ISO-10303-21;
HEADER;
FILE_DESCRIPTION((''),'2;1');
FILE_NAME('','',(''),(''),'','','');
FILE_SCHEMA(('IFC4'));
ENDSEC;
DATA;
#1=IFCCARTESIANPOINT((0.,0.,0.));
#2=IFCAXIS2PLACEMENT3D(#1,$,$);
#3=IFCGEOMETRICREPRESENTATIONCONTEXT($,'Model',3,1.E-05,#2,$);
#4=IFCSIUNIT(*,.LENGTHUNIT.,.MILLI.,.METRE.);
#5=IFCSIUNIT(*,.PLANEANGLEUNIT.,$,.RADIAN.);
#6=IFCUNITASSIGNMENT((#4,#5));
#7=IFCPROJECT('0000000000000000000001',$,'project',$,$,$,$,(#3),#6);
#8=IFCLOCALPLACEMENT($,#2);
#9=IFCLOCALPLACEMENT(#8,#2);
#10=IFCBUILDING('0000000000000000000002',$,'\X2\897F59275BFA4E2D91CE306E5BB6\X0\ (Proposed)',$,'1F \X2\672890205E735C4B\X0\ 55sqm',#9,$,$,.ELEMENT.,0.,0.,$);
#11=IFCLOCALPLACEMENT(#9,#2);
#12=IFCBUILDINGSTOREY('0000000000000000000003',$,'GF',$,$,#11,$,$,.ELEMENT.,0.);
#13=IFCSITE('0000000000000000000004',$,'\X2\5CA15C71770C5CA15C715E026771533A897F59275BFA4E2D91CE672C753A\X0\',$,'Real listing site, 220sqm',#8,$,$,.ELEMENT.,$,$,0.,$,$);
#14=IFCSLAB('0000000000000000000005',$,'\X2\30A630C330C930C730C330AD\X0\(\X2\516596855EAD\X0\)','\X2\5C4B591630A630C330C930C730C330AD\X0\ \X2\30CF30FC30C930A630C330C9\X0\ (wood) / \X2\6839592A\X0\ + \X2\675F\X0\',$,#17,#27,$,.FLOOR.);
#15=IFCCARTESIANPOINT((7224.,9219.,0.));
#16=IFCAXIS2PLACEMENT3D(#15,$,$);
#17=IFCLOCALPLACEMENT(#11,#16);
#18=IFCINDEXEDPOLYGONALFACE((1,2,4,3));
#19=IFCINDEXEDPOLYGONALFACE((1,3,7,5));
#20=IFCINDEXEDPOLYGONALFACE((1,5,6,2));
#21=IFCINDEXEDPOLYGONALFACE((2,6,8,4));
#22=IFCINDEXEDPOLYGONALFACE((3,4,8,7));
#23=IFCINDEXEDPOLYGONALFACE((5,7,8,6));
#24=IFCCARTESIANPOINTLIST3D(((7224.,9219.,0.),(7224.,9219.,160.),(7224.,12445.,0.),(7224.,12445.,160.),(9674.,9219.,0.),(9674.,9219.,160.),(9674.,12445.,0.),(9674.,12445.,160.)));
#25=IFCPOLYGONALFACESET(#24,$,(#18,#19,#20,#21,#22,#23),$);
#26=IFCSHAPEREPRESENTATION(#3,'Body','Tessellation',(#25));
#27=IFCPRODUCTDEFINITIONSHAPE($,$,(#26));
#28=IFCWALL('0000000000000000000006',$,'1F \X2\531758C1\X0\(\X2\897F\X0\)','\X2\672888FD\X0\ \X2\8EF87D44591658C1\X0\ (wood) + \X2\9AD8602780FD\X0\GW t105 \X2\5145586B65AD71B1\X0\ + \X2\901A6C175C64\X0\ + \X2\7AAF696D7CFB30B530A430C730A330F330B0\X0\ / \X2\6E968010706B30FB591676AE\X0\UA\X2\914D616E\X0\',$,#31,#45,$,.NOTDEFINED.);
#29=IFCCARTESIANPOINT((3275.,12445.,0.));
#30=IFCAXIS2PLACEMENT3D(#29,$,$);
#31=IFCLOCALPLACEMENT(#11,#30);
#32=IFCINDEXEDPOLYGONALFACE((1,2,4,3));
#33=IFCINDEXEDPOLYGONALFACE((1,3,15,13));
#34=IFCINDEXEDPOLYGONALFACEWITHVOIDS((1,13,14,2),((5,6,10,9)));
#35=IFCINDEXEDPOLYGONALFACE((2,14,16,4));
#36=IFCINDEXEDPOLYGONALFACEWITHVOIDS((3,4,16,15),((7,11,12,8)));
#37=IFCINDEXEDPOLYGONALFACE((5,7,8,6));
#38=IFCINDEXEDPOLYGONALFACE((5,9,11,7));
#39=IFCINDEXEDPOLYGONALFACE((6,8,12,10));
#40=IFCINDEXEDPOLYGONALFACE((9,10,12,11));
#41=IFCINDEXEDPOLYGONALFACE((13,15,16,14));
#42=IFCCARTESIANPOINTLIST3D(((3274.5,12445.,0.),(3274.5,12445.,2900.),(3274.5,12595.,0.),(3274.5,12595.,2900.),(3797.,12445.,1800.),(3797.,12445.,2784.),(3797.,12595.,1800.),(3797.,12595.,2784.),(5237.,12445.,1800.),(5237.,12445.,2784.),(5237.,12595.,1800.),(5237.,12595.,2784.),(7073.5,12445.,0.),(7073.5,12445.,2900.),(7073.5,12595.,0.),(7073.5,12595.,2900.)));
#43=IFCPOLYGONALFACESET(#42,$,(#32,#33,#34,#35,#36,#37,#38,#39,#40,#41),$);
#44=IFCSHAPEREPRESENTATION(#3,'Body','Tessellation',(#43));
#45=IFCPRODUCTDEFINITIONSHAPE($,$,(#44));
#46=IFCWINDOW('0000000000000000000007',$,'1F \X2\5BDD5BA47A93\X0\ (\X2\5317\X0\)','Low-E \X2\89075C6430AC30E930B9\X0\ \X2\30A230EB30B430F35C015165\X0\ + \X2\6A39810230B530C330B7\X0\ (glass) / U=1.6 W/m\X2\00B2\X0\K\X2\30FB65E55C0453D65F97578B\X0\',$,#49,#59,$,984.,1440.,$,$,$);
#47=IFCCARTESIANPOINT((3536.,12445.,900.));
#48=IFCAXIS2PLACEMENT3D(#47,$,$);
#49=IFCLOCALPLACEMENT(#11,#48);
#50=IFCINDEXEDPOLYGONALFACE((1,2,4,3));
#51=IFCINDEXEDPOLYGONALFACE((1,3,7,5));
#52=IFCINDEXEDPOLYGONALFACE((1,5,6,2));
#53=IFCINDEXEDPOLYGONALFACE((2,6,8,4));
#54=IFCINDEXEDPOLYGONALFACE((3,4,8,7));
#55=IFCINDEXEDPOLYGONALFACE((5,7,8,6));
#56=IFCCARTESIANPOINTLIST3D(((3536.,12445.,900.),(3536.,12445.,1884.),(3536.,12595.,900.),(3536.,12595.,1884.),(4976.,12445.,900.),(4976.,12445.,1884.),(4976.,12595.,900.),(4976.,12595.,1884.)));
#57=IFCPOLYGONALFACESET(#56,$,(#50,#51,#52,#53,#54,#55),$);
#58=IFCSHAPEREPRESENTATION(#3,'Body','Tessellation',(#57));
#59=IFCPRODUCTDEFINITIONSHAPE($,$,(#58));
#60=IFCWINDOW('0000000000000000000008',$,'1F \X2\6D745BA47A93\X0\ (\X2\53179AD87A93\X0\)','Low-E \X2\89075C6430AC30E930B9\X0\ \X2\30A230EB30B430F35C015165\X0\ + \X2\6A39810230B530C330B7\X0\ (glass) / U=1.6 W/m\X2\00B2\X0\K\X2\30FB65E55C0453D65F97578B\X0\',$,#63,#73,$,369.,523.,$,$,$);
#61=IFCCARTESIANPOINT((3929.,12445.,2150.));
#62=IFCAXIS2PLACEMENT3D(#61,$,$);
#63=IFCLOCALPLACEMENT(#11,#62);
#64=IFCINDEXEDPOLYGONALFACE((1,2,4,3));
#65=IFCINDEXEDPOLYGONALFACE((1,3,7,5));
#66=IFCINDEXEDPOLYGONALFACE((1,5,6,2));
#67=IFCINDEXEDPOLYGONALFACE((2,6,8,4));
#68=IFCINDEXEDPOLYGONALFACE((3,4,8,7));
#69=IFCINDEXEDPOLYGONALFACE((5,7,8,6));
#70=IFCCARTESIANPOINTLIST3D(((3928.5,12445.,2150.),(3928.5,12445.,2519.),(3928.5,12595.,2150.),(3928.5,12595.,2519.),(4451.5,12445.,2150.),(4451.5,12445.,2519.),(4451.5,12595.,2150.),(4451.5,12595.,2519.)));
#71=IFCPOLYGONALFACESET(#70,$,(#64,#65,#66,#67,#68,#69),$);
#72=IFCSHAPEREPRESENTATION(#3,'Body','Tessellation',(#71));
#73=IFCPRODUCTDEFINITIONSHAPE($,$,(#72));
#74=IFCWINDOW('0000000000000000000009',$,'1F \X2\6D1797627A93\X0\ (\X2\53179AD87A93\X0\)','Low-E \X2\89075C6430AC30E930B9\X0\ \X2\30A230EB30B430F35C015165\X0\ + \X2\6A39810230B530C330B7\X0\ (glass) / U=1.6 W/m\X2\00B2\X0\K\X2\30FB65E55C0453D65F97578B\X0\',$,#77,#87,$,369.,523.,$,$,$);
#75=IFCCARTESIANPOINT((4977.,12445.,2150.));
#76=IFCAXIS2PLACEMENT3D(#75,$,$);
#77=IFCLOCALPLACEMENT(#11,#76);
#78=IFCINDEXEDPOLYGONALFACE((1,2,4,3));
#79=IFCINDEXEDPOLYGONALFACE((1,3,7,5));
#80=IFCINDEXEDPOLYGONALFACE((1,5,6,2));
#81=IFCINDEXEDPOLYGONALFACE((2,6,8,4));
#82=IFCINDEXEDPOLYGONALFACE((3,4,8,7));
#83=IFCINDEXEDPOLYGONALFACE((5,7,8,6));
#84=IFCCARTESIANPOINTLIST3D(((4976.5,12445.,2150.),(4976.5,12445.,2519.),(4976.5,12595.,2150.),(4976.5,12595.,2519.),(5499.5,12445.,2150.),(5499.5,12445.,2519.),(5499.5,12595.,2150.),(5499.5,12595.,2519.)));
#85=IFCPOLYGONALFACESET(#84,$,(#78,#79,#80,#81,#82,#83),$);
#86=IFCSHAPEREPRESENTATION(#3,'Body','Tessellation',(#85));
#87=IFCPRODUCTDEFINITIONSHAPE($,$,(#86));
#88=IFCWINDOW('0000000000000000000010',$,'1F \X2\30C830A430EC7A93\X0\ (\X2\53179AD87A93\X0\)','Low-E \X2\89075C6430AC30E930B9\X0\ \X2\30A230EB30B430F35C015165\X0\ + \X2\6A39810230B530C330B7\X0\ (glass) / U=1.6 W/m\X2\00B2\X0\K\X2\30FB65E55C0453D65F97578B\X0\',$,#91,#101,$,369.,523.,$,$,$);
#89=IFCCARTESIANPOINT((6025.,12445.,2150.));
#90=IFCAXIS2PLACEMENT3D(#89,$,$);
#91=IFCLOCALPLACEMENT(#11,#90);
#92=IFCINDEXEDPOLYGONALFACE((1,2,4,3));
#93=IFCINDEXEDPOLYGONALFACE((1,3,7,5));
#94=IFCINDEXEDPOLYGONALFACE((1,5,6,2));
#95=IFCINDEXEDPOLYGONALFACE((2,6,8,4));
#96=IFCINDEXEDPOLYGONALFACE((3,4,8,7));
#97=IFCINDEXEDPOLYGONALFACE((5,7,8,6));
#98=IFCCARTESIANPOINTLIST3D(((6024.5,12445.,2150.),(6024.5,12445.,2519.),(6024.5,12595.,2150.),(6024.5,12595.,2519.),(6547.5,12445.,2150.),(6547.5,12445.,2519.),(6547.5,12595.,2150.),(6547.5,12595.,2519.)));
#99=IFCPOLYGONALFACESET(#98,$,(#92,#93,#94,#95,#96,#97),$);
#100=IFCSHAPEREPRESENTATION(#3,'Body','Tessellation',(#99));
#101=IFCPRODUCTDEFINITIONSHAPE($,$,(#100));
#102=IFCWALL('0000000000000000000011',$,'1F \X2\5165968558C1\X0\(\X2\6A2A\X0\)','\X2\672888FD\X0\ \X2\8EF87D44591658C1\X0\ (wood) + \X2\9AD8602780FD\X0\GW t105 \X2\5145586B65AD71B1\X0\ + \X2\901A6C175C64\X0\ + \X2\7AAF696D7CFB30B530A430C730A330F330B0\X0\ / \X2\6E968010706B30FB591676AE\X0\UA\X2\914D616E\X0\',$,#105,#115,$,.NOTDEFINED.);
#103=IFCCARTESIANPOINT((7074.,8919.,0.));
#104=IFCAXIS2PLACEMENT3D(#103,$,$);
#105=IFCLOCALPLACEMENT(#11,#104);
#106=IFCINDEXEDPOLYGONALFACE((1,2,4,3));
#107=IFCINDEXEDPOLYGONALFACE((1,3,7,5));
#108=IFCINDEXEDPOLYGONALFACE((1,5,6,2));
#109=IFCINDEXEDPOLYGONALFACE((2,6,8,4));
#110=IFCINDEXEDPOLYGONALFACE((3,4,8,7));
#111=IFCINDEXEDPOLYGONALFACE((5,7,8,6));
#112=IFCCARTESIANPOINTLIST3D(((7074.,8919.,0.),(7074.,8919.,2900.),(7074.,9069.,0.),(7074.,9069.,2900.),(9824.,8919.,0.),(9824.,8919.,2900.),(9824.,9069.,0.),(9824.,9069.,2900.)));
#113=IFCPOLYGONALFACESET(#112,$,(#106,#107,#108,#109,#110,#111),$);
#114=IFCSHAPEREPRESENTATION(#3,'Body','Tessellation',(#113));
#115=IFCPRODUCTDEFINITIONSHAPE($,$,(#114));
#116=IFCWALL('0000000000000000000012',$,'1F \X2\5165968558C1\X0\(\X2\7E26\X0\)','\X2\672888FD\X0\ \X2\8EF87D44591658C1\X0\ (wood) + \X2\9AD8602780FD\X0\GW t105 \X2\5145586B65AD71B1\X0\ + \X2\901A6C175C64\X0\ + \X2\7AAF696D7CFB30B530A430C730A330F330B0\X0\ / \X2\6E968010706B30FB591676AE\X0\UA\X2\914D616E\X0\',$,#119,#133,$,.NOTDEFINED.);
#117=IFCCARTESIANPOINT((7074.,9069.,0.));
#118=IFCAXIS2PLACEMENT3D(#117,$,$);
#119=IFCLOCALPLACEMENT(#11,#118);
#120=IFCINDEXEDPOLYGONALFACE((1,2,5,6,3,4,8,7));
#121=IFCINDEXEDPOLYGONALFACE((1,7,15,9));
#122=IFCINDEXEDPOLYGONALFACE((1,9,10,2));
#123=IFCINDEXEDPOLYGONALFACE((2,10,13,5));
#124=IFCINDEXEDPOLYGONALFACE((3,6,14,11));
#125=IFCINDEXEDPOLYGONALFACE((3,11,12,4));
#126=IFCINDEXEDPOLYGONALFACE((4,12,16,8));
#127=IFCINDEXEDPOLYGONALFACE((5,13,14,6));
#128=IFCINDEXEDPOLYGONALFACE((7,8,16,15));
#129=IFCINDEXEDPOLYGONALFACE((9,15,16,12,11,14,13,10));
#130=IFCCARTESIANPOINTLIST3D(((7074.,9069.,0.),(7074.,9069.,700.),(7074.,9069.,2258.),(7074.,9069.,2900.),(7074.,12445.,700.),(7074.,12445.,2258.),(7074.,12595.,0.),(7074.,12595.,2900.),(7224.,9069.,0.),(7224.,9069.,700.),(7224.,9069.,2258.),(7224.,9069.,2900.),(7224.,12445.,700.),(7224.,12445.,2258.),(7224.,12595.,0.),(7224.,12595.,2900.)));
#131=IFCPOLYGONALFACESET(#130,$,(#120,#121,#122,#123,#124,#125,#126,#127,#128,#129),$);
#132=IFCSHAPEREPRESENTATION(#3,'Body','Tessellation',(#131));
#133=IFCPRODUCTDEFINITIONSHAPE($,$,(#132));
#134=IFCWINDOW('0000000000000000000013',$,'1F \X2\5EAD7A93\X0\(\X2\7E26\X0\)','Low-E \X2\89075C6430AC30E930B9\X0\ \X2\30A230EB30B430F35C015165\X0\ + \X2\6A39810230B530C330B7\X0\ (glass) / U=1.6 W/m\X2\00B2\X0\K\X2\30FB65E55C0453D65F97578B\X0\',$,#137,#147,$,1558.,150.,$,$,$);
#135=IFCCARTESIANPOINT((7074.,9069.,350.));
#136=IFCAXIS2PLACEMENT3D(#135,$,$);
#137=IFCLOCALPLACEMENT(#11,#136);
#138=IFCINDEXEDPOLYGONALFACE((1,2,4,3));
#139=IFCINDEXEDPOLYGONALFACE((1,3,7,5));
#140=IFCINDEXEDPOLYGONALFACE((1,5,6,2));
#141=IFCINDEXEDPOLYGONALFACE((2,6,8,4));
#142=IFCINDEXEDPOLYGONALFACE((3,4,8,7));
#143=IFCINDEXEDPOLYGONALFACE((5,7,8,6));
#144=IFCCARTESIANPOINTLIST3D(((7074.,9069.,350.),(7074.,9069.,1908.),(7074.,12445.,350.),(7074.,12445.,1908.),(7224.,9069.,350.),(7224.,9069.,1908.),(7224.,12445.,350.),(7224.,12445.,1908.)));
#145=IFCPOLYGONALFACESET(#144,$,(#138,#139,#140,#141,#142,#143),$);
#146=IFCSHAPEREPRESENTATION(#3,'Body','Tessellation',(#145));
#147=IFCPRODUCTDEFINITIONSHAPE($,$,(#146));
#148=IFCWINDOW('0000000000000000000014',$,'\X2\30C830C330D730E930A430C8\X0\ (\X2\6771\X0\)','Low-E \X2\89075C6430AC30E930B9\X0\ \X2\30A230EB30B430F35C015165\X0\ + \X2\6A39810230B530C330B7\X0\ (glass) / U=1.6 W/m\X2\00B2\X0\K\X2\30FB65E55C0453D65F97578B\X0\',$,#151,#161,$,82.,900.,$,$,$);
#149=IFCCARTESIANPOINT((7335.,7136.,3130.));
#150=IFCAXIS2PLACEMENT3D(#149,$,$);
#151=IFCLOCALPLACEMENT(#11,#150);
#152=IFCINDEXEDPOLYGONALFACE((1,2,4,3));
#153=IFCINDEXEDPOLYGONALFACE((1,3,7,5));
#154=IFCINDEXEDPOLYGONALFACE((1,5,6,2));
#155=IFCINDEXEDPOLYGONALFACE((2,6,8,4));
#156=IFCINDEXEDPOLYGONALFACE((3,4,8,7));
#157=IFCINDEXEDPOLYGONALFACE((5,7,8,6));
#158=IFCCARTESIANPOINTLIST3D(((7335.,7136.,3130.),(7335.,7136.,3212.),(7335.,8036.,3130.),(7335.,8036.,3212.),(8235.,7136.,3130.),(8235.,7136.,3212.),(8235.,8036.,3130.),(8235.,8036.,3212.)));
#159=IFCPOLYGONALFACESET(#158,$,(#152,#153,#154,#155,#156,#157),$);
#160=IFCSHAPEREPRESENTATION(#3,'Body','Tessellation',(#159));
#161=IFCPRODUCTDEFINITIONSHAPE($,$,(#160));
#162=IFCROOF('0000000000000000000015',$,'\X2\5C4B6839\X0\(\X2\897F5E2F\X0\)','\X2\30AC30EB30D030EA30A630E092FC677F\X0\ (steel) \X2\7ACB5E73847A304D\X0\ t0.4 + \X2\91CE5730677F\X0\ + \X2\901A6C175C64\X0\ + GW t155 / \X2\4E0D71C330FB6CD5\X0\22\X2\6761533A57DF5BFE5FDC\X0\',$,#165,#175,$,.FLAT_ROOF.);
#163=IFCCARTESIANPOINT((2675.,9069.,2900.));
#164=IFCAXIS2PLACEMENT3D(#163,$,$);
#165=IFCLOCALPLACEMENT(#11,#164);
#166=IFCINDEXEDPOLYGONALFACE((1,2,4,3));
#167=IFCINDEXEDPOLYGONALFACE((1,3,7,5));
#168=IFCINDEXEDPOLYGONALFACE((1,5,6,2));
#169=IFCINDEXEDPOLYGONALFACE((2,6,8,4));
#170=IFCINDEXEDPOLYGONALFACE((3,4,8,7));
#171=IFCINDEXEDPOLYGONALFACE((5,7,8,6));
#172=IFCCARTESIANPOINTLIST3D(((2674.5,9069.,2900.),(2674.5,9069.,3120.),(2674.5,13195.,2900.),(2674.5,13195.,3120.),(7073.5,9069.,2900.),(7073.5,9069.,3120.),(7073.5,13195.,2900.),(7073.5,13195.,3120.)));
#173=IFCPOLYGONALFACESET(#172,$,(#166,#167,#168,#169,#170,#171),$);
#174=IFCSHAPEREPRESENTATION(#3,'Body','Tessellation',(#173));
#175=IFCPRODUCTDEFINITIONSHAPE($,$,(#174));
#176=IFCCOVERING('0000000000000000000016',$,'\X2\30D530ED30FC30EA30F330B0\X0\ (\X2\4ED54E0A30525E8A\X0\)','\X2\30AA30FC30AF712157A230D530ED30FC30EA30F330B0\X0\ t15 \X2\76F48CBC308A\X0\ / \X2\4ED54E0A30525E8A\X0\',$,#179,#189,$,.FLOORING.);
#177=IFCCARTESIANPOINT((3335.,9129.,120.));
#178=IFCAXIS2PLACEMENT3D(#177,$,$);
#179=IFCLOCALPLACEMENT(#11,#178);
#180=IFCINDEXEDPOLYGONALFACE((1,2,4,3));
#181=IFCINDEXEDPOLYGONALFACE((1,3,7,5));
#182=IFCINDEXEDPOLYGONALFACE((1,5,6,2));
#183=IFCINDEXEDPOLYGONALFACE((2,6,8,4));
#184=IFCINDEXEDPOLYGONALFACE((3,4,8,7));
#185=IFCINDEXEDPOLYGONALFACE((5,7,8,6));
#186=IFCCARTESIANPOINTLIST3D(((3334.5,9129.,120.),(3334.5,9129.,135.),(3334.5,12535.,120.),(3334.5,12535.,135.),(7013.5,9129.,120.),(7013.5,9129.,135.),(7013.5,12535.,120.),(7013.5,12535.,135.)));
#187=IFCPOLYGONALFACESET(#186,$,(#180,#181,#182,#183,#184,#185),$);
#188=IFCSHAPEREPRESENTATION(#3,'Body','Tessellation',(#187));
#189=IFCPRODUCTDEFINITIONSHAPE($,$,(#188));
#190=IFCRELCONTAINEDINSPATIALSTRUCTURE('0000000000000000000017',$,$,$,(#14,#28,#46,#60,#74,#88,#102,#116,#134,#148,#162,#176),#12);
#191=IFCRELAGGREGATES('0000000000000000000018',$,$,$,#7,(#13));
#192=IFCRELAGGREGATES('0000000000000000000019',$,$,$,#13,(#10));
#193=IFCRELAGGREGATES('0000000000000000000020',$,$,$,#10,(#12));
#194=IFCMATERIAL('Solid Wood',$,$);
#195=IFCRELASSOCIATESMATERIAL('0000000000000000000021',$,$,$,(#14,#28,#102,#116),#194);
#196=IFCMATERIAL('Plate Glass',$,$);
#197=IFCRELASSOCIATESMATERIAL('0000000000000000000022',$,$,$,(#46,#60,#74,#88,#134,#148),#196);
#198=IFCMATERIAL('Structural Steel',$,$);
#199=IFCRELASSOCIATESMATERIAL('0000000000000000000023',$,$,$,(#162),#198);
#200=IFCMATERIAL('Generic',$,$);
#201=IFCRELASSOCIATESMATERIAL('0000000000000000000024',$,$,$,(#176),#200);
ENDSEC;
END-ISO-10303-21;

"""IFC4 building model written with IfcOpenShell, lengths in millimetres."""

from ifc_helpers import new_model, si_unit, frame, frame_2d, origin, place, context, project, spatial, rectangle, extrude, material, element, fill, save


model = new_model("IFC4")

# Units and contexts
model_context = context("Model", 3, precision=1e-05, world=origin())
ifc_project = project(units=[si_unit("LENGTHUNIT", "METRE", prefix="MILLI"), si_unit("PLANEANGLEUNIT", "RADIAN")], contexts=[model_context])

# Site, building, storey
site_placement = place(None, origin())
site = spatial("IfcSite", under=ifc_project, at=site_placement, Name="岡山県岡山市東区西大寺中野本町", ObjectType="Real listing site, 220sqm", CompositionType="ELEMENT", RefElevation=0.0)
building_placement = place(site_placement, origin())
building = spatial("IfcBuilding", under=site, at=building_placement, Name="西大寺中野の家 (Proposed)", ObjectType="1F 木造平屋 55sqm", CompositionType="ELEMENT", ElevationOfRefHeight=0.0, ElevationOfTerrain=0.0)
storey_placement = place(building_placement, origin())
storey = spatial("IfcBuildingStorey", under=building, at=storey_placement, Name="GF", CompositionType="ELEMENT", Elevation=0.0)

# Slab
ifc_material_1 = material(Name="Solid Wood")
slab_1_placement = place(storey_placement, frame((7224.0, 9219.0, 0.0)))
element("IfcSlab", 1, at=slab_1_placement, inside=storey, material=ifc_material_1, Name="ウッドデッキ(入隅庭)", Description="屋外ウッドデッキ ハードウッド (wood) / 根太 + 束", PredefinedType="FLOOR", context=model_context, shape_type="SweptSolid", body=[
    extrude(rectangle(XDim=2450.0, YDim=3226.0, at=frame_2d((1225.0, 1613.0))), frame((7224.0, 9219.0, 0.0)), (0.0, 0.0, 1.0), 160.0),
])

# Wall, openings, windows
wall_1_placement = place(storey_placement, frame((3275.0, 12445.0, 0.0)))
wall_1 = element("IfcWall", 2, at=wall_1_placement, inside=storey, material=ifc_material_1, Name="1F 北壁(西)", Description="木製 軸組外壁 (wood) + 高性能GW t105 充填断熱 + 通気層 + 窯業系サイディング / 準耐火・外皮UA配慮", PredefinedType="NOTDEFINED", context=model_context, shape_type="SweptSolid", body=[
    extrude(rectangle(XDim=3799.0, YDim=150.0, at=frame_2d((1899.0, 75.0))), frame((3275.0, 12445.0, 0.0)), (0.0, 0.0, 1.0), 2900.0),
])
opening_1_placement = place(storey_placement, frame((3536.0, 12445.0, 900.0)))
opening_1 = element("IfcOpeningElement", 3, at=opening_1_placement, cuts=wall_1, PredefinedType="NOTDEFINED", context=model_context, shape_type="SweptSolid", body=[
    extrude(rectangle(XDim=1440.0, YDim=150.0, at=frame_2d((720.0, 75.0))), frame((3536.0, 12445.0, 900.0)), (0.0, 0.0, 1.0), 984.0),
])
opening_2_placement = place(storey_placement, frame((3929.0, 12445.0, 2150.0)))
opening_2 = element("IfcOpeningElement", 4, at=opening_2_placement, cuts=wall_1, PredefinedType="NOTDEFINED", context=model_context, shape_type="SweptSolid", body=[
    extrude(rectangle(XDim=523.0, YDim=150.0, at=frame_2d((261.0, 75.0))), frame((3929.0, 12445.0, 2150.0)), (0.0, 0.0, 1.0), 369.0),
])
opening_3_placement = place(storey_placement, frame((4977.0, 12445.0, 2150.0)))
opening_3 = element("IfcOpeningElement", 5, at=opening_3_placement, cuts=wall_1, PredefinedType="NOTDEFINED", context=model_context, shape_type="SweptSolid", body=[
    extrude(rectangle(XDim=523.0, YDim=150.0, at=frame_2d((261.0, 75.0))), frame((4977.0, 12445.0, 2150.0)), (0.0, 0.0, 1.0), 369.0),
])
opening_4_placement = place(storey_placement, frame((6025.0, 12445.0, 2150.0)))
opening_4 = element("IfcOpeningElement", 6, at=opening_4_placement, cuts=wall_1, PredefinedType="NOTDEFINED", context=model_context, shape_type="SweptSolid", body=[
    extrude(rectangle(XDim=523.0, YDim=150.0, at=frame_2d((261.0, 75.0))), frame((6025.0, 12445.0, 2150.0)), (0.0, 0.0, 1.0), 369.0),
])
ifc_material_2 = material(Name="Plate Glass")
window_1_placement = place(storey_placement, frame((3536.0, 12445.0, 900.0)))
window_1 = element("IfcWindow", 7, at=window_1_placement, inside=storey, material=ifc_material_2, Name="1F 寝室窓 (北)", Description="Low-E 複層ガラス アルゴン封入 + 樹脂サッシ (glass) / U=1.6 W/m²K・日射取得型", OverallHeight=984.0, OverallWidth=1440.0, context=model_context, shape_type="SweptSolid", body=[
    extrude(rectangle(XDim=1440.0, YDim=150.0, at=frame_2d((720.0, 75.0))), frame((3536.0, 12445.0, 900.0)), (0.0, 0.0, 1.0), 984.0),
])
fill(opening_1, window_1)
window_2_placement = place(storey_placement, frame((3929.0, 12445.0, 2150.0)))
window_2 = element("IfcWindow", 8, at=window_2_placement, inside=storey, material=ifc_material_2, Name="1F 浴室窓 (北高窓)", Description="Low-E 複層ガラス アルゴン封入 + 樹脂サッシ (glass) / U=1.6 W/m²K・日射取得型", OverallHeight=369.0, OverallWidth=523.0, context=model_context, shape_type="SweptSolid", body=[
    extrude(rectangle(XDim=523.0, YDim=150.0, at=frame_2d((261.0, 75.0))), frame((3929.0, 12445.0, 2150.0)), (0.0, 0.0, 1.0), 369.0),
])
fill(opening_2, window_2)
window_3_placement = place(storey_placement, frame((4977.0, 12445.0, 2150.0)))
window_3 = element("IfcWindow", 9, at=window_3_placement, inside=storey, material=ifc_material_2, Name="1F 洗面窓 (北高窓)", Description="Low-E 複層ガラス アルゴン封入 + 樹脂サッシ (glass) / U=1.6 W/m²K・日射取得型", OverallHeight=369.0, OverallWidth=523.0, context=model_context, shape_type="SweptSolid", body=[
    extrude(rectangle(XDim=523.0, YDim=150.0, at=frame_2d((261.0, 75.0))), frame((4977.0, 12445.0, 2150.0)), (0.0, 0.0, 1.0), 369.0),
])
fill(opening_3, window_3)
window_4_placement = place(storey_placement, frame((6025.0, 12445.0, 2150.0)))
window_4 = element("IfcWindow", 10, at=window_4_placement, inside=storey, material=ifc_material_2, Name="1F トイレ窓 (北高窓)", Description="Low-E 複層ガラス アルゴン封入 + 樹脂サッシ (glass) / U=1.6 W/m²K・日射取得型", OverallHeight=369.0, OverallWidth=523.0, context=model_context, shape_type="SweptSolid", body=[
    extrude(rectangle(XDim=523.0, YDim=150.0, at=frame_2d((261.0, 75.0))), frame((6025.0, 12445.0, 2150.0)), (0.0, 0.0, 1.0), 369.0),
])
fill(opening_4, window_4)

# Wall
wall_2_placement = place(storey_placement, frame((7074.0, 8919.0, 0.0)))
element("IfcWall", 11, at=wall_2_placement, inside=storey, material=ifc_material_1, Name="1F 入隅壁(横)", Description="木製 軸組外壁 (wood) + 高性能GW t105 充填断熱 + 通気層 + 窯業系サイディング / 準耐火・外皮UA配慮", PredefinedType="NOTDEFINED", context=model_context, shape_type="SweptSolid", body=[
    extrude(rectangle(XDim=2750.0, YDim=150.0, at=frame_2d((1375.0, 75.0))), frame((7074.0, 8919.0, 0.0)), (0.0, 0.0, 1.0), 2900.0),
])

# Wall, opening, window
wall_3_placement = place(storey_placement, frame((7074.0, 9069.0, 0.0)))
wall_3 = element("IfcWall", 12, at=wall_3_placement, inside=storey, material=ifc_material_1, Name="1F 入隅壁(縦)", Description="木製 軸組外壁 (wood) + 高性能GW t105 充填断熱 + 通気層 + 窯業系サイディング / 準耐火・外皮UA配慮", PredefinedType="NOTDEFINED", context=model_context, shape_type="SweptSolid", body=[
    extrude(rectangle(XDim=150.0, YDim=3526.0, at=frame_2d((75.0, 1763.0))), frame((7074.0, 9069.0, 0.0)), (0.0, 0.0, 1.0), 2900.0),
])
opening_5_placement = place(storey_placement, frame((7074.0, 9069.0, 350.0)))
opening_5 = element("IfcOpeningElement", 13, at=opening_5_placement, cuts=wall_3, PredefinedType="NOTDEFINED", context=model_context, shape_type="SweptSolid", body=[
    extrude(rectangle(XDim=150.0, YDim=3376.0, at=frame_2d((75.0, 1688.0))), frame((7074.0, 9069.0, 350.0)), (0.0, 0.0, 1.0), 1558.0),
])
window_5_placement = place(storey_placement, frame((7074.0, 9069.0, 350.0)))
window_5 = element("IfcWindow", 14, at=window_5_placement, inside=storey, material=ifc_material_2, Name="1F 庭窓(縦)", Description="Low-E 複層ガラス アルゴン封入 + 樹脂サッシ (glass) / U=1.6 W/m²K・日射取得型", OverallHeight=1558.0, OverallWidth=150.0, context=model_context, shape_type="SweptSolid", body=[
    extrude(rectangle(XDim=150.0, YDim=3376.0, at=frame_2d((75.0, 1688.0))), frame((7074.0, 9069.0, 350.0)), (0.0, 0.0, 1.0), 1558.0),
])
fill(opening_5, window_5)

# Window
window_6_placement = place(storey_placement, frame((7335.0, 7136.0, 3130.0)))
element("IfcWindow", 15, at=window_6_placement, inside=storey, material=ifc_material_2, Name="トップライト (東)", Description="Low-E 複層ガラス アルゴン封入 + 樹脂サッシ (glass) / U=1.6 W/m²K・日射取得型", OverallHeight=82.0, OverallWidth=900.0, context=model_context, shape_type="SweptSolid", body=[
    extrude(rectangle(XDim=900.0, YDim=900.0, at=frame_2d((450.0, 450.0))), frame((7335.0, 7136.0, 3130.0)), (0.0, 0.0, 1.0), 82.0),
])

# Roof
ifc_material_3 = material(Name="Structural Steel")
roof_placement = place(storey_placement, frame((2675.0, 9069.0, 2900.0)))
element("IfcRoof", 16, at=roof_placement, inside=storey, material=ifc_material_3, Name="屋根(西帯)", Description="ガルバリウム鋼板 (steel) 立平葺き t0.4 + 野地板 + 通気層 + GW t155 / 不燃・法22条区域対応", PredefinedType="FLAT_ROOF", context=model_context, shape_type="SweptSolid", body=[
    extrude(rectangle(XDim=4399.0, YDim=4126.0, at=frame_2d((2199.0, 2063.0))), frame((2675.0, 9069.0, 2900.0)), (0.0, 0.0, 1.0), 220.0),
])

# Covering
ifc_material_4 = material(Name="Generic")
covering_placement = place(storey_placement, frame((3335.0, 9129.0, 120.0)))
element("IfcCovering", 17, at=covering_placement, inside=storey, material=ifc_material_4, Name="フローリング (仕上げ床)", Description="オーク無垢フローリング t15 直貼り / 仕上げ床", PredefinedType="FLOORING", context=model_context, shape_type="SweptSolid", body=[
    extrude(rectangle(XDim=3679.0, YDim=3406.0, at=frame_2d((1839.0, 1703.0))), frame((3335.0, 9129.0, 120.0)), (0.0, 0.0, 1.0), 15.0),
])

save(model, "model.ifc")
